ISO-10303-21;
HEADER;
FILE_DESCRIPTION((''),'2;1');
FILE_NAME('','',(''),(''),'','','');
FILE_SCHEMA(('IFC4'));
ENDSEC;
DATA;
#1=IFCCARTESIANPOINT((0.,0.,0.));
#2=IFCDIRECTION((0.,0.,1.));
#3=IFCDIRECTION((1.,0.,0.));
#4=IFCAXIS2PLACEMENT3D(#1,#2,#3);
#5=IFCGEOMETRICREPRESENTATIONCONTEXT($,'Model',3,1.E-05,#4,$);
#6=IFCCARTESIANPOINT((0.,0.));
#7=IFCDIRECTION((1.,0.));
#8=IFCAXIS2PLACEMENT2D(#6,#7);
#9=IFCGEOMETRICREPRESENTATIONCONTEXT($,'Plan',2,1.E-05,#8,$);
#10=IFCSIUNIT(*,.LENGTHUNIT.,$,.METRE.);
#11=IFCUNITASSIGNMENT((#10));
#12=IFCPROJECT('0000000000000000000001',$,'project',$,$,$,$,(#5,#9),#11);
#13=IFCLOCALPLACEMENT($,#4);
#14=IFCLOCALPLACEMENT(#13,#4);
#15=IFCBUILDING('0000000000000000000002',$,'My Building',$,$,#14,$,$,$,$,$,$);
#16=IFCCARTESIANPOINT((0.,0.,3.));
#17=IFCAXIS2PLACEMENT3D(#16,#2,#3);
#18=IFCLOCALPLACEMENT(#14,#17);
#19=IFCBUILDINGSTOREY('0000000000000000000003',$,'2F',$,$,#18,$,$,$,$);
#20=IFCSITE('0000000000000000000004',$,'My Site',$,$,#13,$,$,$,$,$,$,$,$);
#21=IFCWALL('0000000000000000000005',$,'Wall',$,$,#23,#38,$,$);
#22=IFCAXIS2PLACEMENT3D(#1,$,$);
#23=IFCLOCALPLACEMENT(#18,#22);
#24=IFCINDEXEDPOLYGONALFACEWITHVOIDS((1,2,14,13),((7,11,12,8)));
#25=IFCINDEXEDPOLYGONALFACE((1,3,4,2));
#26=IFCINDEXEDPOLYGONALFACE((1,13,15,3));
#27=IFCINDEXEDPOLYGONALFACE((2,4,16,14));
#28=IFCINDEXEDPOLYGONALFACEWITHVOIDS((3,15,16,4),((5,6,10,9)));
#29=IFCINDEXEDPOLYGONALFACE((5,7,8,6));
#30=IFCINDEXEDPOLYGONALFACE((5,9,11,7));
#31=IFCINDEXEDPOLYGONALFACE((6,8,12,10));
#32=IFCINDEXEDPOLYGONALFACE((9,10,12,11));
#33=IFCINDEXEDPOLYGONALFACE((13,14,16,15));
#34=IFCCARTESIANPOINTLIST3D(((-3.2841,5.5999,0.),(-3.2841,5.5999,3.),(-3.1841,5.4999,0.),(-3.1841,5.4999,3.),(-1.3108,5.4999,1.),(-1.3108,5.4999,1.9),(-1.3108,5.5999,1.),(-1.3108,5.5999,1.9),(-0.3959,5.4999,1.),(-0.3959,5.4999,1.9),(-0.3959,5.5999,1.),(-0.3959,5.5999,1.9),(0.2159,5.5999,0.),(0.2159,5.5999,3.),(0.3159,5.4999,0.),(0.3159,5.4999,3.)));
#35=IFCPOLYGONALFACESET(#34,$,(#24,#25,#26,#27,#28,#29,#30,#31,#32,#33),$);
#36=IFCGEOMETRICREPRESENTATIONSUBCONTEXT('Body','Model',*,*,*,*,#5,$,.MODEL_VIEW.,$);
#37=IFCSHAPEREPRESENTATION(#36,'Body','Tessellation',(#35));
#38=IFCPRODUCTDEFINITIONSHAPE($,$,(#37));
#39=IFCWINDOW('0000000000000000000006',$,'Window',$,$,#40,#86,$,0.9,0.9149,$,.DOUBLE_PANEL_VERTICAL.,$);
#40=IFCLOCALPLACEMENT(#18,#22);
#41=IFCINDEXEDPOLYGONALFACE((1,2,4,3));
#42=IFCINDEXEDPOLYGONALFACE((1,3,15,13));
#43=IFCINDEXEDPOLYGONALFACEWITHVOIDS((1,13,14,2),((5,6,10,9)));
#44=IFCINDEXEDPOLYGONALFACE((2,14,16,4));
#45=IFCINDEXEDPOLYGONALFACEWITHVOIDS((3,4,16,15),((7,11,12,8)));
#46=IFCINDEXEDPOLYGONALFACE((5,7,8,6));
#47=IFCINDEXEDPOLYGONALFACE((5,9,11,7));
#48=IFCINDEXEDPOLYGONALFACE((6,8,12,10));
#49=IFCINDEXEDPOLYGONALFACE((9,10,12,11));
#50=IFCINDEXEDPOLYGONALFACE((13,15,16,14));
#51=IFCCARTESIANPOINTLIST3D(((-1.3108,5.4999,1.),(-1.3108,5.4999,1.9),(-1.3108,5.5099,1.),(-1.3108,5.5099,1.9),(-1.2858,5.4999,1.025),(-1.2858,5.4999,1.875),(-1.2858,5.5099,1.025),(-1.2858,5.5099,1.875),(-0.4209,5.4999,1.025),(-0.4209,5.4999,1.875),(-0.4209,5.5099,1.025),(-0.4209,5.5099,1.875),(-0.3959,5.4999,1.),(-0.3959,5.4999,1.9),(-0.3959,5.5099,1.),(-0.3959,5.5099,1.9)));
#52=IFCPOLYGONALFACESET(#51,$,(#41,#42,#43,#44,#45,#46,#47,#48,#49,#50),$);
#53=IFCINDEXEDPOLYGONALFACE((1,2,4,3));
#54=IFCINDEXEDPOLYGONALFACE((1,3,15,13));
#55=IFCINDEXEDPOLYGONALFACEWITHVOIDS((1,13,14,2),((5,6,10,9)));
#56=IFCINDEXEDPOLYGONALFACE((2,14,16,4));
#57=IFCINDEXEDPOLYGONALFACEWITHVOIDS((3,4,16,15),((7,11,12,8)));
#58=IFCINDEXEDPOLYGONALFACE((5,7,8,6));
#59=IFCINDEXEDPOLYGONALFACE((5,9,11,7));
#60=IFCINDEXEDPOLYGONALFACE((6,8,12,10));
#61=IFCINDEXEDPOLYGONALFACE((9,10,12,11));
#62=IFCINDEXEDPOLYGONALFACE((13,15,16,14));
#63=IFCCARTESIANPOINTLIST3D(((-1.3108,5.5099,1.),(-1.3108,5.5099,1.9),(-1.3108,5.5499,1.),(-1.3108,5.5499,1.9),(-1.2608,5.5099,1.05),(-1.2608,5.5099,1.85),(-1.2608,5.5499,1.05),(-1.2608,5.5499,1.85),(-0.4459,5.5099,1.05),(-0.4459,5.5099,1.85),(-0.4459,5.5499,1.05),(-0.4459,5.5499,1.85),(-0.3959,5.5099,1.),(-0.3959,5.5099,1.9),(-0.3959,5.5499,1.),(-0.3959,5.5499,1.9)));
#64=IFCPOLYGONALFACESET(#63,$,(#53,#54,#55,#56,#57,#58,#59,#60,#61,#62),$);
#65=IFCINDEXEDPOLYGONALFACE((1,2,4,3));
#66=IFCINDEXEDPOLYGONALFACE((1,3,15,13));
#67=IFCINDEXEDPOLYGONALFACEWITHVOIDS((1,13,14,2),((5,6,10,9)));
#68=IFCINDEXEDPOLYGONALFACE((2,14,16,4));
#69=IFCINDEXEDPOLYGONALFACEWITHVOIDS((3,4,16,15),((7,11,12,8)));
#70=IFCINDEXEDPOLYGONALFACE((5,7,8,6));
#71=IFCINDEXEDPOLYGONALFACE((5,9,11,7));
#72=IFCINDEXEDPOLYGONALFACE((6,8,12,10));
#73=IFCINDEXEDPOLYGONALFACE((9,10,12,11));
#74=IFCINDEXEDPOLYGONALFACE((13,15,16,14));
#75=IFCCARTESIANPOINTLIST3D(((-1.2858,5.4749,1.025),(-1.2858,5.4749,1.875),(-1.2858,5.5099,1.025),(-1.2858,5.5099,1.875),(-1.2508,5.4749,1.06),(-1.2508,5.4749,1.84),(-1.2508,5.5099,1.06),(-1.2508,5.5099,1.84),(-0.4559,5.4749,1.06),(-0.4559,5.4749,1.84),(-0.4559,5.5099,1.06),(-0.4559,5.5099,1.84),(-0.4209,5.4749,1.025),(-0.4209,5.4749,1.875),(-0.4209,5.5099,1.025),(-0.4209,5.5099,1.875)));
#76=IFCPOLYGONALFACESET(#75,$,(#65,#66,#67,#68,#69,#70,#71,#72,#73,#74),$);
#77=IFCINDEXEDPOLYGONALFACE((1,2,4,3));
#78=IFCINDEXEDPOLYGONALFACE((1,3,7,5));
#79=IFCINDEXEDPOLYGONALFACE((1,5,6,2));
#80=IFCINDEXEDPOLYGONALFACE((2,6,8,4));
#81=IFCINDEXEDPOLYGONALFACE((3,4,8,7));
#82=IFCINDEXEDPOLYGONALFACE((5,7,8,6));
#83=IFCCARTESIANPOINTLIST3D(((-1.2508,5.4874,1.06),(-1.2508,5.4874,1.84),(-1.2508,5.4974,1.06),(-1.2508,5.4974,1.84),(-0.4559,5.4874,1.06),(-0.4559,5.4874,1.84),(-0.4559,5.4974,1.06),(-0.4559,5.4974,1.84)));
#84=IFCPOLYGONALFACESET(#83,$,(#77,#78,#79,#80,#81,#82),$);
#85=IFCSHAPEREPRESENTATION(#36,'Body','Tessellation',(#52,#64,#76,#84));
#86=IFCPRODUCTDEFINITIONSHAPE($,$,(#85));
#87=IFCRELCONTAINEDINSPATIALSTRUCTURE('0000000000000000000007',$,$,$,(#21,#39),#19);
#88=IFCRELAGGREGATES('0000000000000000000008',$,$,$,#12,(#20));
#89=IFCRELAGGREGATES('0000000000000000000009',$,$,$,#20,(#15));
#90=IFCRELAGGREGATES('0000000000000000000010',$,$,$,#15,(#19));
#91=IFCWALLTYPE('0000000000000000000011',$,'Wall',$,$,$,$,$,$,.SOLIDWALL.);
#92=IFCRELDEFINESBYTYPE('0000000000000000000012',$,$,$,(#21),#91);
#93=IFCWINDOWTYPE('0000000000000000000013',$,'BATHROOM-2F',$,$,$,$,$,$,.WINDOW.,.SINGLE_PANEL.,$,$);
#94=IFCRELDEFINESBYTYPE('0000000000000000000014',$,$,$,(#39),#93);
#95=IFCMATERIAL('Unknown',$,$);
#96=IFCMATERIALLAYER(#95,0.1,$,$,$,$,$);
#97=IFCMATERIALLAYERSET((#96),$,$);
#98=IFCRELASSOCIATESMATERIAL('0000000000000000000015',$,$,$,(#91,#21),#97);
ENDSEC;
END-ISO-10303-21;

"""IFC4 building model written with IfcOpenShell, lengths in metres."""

from ifc_helpers import new_model, entity, si_unit, frame, origin_with_axes, origin_2d_with_axis, place, context, subcontext, project, spatial, line, indexed_curve, outline, extrude, shape, source, transform, mapped, material, layer, layer_set, layer_usage, type_object, type_shapes, element, fill, save


model = new_model("IFC4")

# Units and contexts
model_context = context("Model", 3, precision=1e-05, world=origin_with_axes())
plan_context = context("Plan", 2, precision=1e-05, world=origin_2d_with_axis())
body_context_1 = subcontext(model_context, "Body", "Model", "MODEL_VIEW")
body_context_2 = subcontext(plan_context, "Body", "Plan", "PLAN_VIEW")
ifc_project = project(units=[si_unit("LENGTHUNIT", "METRE")], contexts=[model_context, plan_context])

# Site, building, storey
site_placement = place(None, origin_with_axes())
site = spatial("IfcSite", under=ifc_project, at=site_placement, Name="My Site")
building_placement = place(site_placement, origin_with_axes())
building = spatial("IfcBuilding", under=site, at=building_placement, Name="My Building")
storey_placement = place(building_placement, frame((0.0, 0.0, 3.0), z_axis=(0.0, 0.0, 1.0), x_axis=(1.0, 0.0, 0.0)))
storey = spatial("IfcBuildingStorey", under=building, at=storey_placement, Name="2F")

# Shared definitions
ifc_material = material(Name="Unknown")

# Shared definitions
ifc_layer_1 = layer(ifc_material, 0.1)
ifc_layer_set_1 = layer_set([ifc_layer_1])
wall_type = type_object("IfcWallType", Name="Wall", PredefinedType="SOLIDWALL", material=ifc_layer_set_1)

# Wall, opening, window
ifc_layer_usage_1 = layer_usage(ifc_layer_set_1, "AXIS2", "POSITIVE", 0.0)
wall_1_placement = place(storey_placement, frame((0.2159, 5.5999, 0.0), z_axis=(0.0, 0.0, 1.0), x_axis=(-1.0, 0.0, 0.0)))
wall_1 = element("IfcWall", 1, at=wall_1_placement, inside=storey, type_object=wall_type, material=ifc_layer_usage_1, Name="Wall", context=body_context_1, shape_type="SweptSolid", body=[
    extrude(outline(indexed_curve([(0.0, 0.0), (-0.1, 0.1), (3.4, 0.1), (3.5, 0.0)], segments=[line(1, 2, 3, 4, 1)])), origin_with_axes(), (0.0, 0.0, 1.0), 3.0),
])
shared_shape_1 = source(origin_with_axes(), body_context_1, "Body", "SweptSolid", [
    extrude(outline(indexed_curve([(0.0, 0.0), (0.9149, 0.0), (0.9149, 0.9), (0.0, 0.9)], segments=[line(1, 2, 3, 4, 1)])), frame((0.0, -0.6, 0.0), z_axis=(0.0, -1.0, 0.0), x_axis=(1.0, 0.0, 0.0)), (0.0, 0.0, -1.0), 1.2),
])
opening_1_placement = place(wall_1_placement, frame((0.6117, 0.0, 1.0), z_axis=(0.0, 0.0, 1.0), x_axis=(1.0, -0.000001, 0.0)))
opening_1 = element("IfcOpeningElement", 2, at=opening_1_placement, cuts=wall_1, PredefinedType="OPENING", context=body_context_1, shape_type="MappedRepresentation", body=[
    mapped(shared_shape_1, transform((0.0, 0.0, 0.0), x_axis=(1.0, 0.0, 0.0), y_axis=(0.0, 1.0, 0.0), z_axis=(0.0, 0.0, 1.0), scale=1.0)),
])
window_type_1 = type_object("IfcWindowType", Name="BATHROOM-2F", PartitioningType="SINGLE_PANEL", PredefinedType="WINDOW")
shared_shape_2 = source(origin_with_axes(), body_context_1, "Body", "SweptSolid", [
    extrude(outline(indexed_curve([(0.0, 0.0), (0.9149, 0.0), (0.9149, 0.9), (0.0, 0.9)], segments=[line(1, 2, 3, 4, 1)]), holes=[indexed_curve([(0.025, 0.025), (0.8899, 0.025), (0.8899, 0.875), (0.025, 0.875)], segments=[line(1, 2, 3, 4, 1)])]), frame((0.0, 0.09, 0.0), z_axis=(0.0, -1.0, 0.0), x_axis=(1.0, 0.0, 0.0)), (0.0, 0.0, -1.0), 0.01),
    extrude(outline(indexed_curve([(0.0, 0.0), (0.9149, 0.0), (0.9149, 0.9), (0.0, 0.9)], segments=[line(1, 2, 3, 4, 1)]), holes=[indexed_curve([(0.05, 0.05), (0.8649, 0.05), (0.8649, 0.85), (0.05, 0.85)], segments=[line(1, 2, 3, 4, 1)])]), frame((0.0, 0.05, 0.0), z_axis=(0.0, -1.0, 0.0), x_axis=(1.0, 0.0, 0.0)), (0.0, 0.0, -1.0), 0.04),
    extrude(outline(indexed_curve([(0.0, 0.0), (0.8649, 0.0), (0.8649, 0.85), (0.0, 0.85)], segments=[line(1, 2, 3, 4, 1)]), holes=[indexed_curve([(0.035, 0.035), (0.8299, 0.035), (0.8299, 0.815), (0.035, 0.815)], segments=[line(1, 2, 3, 4, 1)])]), frame((0.025, 0.09, 0.025), z_axis=(0.0, -1.0, 0.0), x_axis=(1.0, 0.0, 0.0)), (0.0, 0.0, -1.0), 0.035),
    extrude(outline(indexed_curve([(0.035, 0.035), (0.8299, 0.035), (0.8299, 0.815), (0.035, 0.815)], segments=[line(1, 2, 3, 4, 1)])), frame((0.025, 0.1025, 0.025), z_axis=(0.0, -1.0, 0.0), x_axis=(1.0, 0.0, 0.0)), (0.0, 0.0, -1.0), 0.01),
])
shared_shape_3 = source(origin_with_axes(), body_context_2, "Body", "Curve2D", [
    entity("IfcIndexedPolyCurve", entity("IfcCartesianPointList2D", [[0.05, 0.05], [0.8649, 0.05]])),
    entity("IfcIndexedPolyCurve", entity("IfcCartesianPointList2D", [[0.0, 0.1], [0.025, 0.1], [0.025, 0.09], [0.05, 0.09], [0.05, 0.05], [0.0, 0.05]]), [entity("IfcLineIndex", [1, 2, 3, 4, 5, 6, 1])]),
    entity("IfcIndexedPolyCurve", entity("IfcCartesianPointList2D", [[0.9149, 0.1], [0.8899, 0.1], [0.8899, 0.09], [0.8649, 0.09], [0.8649, 0.05], [0.9149, 0.05]]), [entity("IfcLineIndex", [1, 2, 3, 4, 5, 6, 1])]),
    entity("IfcIndexedPolyCurve", entity("IfcCartesianPointList2D", [[0.025, 0.09], [0.06, 0.09], [0.06, 0.125], [0.025, 0.125]]), [entity("IfcLineIndex", [1, 2, 3, 4, 1])]),
    entity("IfcIndexedPolyCurve", entity("IfcCartesianPointList2D", [[0.8899, 0.09], [0.8549, 0.09], [0.8549, 0.125], [0.8899, 0.125]]), [entity("IfcLineIndex", [1, 2, 3, 4, 1])]),
    entity("IfcIndexedPolyCurve", entity("IfcCartesianPointList2D", [[0.06, 0.09], [0.8549, 0.09]])),
    entity("IfcIndexedPolyCurve", entity("IfcCartesianPointList2D", [[0.06, 0.125], [0.8549, 0.125]])),
    entity("IfcIndexedPolyCurve", entity("IfcCartesianPointList2D", [[0.06, 0.1075], [0.8549, 0.1075]])),
])
type_shapes(window_type_1, [shared_shape_2, shared_shape_3])
window_1_placement = place(opening_1_placement, frame((0.0, 0.0, 0.0), z_axis=(0.0, 0.0, 1.0), x_axis=(1.0, 0.0, 0.0)))
window_1 = element("IfcWindow", 3, at=window_1_placement, inside=storey, type_object=window_type_1, Name="Window", OverallHeight=0.9, OverallWidth=0.9149, PartitioningType="DOUBLE_PANEL_VERTICAL", shapes=[
    shape(body_context_1, "Body", "MappedRepresentation", [mapped(shared_shape_2, transform((0.0, 0.0, 0.0), x_axis=(1.0, 0.0, 0.0), y_axis=(0.0, 1.0, 0.0), z_axis=(0.0, 0.0, 1.0), scale=1.0))]),
    shape(body_context_2, "Body", "MappedRepresentation", [mapped(shared_shape_3, transform((0.0, 0.0, 0.0), x_axis=(1.0, 0.0, 0.0), y_axis=(0.0, 1.0, 0.0), z_axis=(0.0, 0.0, 1.0), scale=1.0))]),
])
fill(opening_1, window_1)

save(model, "model.ifc")
